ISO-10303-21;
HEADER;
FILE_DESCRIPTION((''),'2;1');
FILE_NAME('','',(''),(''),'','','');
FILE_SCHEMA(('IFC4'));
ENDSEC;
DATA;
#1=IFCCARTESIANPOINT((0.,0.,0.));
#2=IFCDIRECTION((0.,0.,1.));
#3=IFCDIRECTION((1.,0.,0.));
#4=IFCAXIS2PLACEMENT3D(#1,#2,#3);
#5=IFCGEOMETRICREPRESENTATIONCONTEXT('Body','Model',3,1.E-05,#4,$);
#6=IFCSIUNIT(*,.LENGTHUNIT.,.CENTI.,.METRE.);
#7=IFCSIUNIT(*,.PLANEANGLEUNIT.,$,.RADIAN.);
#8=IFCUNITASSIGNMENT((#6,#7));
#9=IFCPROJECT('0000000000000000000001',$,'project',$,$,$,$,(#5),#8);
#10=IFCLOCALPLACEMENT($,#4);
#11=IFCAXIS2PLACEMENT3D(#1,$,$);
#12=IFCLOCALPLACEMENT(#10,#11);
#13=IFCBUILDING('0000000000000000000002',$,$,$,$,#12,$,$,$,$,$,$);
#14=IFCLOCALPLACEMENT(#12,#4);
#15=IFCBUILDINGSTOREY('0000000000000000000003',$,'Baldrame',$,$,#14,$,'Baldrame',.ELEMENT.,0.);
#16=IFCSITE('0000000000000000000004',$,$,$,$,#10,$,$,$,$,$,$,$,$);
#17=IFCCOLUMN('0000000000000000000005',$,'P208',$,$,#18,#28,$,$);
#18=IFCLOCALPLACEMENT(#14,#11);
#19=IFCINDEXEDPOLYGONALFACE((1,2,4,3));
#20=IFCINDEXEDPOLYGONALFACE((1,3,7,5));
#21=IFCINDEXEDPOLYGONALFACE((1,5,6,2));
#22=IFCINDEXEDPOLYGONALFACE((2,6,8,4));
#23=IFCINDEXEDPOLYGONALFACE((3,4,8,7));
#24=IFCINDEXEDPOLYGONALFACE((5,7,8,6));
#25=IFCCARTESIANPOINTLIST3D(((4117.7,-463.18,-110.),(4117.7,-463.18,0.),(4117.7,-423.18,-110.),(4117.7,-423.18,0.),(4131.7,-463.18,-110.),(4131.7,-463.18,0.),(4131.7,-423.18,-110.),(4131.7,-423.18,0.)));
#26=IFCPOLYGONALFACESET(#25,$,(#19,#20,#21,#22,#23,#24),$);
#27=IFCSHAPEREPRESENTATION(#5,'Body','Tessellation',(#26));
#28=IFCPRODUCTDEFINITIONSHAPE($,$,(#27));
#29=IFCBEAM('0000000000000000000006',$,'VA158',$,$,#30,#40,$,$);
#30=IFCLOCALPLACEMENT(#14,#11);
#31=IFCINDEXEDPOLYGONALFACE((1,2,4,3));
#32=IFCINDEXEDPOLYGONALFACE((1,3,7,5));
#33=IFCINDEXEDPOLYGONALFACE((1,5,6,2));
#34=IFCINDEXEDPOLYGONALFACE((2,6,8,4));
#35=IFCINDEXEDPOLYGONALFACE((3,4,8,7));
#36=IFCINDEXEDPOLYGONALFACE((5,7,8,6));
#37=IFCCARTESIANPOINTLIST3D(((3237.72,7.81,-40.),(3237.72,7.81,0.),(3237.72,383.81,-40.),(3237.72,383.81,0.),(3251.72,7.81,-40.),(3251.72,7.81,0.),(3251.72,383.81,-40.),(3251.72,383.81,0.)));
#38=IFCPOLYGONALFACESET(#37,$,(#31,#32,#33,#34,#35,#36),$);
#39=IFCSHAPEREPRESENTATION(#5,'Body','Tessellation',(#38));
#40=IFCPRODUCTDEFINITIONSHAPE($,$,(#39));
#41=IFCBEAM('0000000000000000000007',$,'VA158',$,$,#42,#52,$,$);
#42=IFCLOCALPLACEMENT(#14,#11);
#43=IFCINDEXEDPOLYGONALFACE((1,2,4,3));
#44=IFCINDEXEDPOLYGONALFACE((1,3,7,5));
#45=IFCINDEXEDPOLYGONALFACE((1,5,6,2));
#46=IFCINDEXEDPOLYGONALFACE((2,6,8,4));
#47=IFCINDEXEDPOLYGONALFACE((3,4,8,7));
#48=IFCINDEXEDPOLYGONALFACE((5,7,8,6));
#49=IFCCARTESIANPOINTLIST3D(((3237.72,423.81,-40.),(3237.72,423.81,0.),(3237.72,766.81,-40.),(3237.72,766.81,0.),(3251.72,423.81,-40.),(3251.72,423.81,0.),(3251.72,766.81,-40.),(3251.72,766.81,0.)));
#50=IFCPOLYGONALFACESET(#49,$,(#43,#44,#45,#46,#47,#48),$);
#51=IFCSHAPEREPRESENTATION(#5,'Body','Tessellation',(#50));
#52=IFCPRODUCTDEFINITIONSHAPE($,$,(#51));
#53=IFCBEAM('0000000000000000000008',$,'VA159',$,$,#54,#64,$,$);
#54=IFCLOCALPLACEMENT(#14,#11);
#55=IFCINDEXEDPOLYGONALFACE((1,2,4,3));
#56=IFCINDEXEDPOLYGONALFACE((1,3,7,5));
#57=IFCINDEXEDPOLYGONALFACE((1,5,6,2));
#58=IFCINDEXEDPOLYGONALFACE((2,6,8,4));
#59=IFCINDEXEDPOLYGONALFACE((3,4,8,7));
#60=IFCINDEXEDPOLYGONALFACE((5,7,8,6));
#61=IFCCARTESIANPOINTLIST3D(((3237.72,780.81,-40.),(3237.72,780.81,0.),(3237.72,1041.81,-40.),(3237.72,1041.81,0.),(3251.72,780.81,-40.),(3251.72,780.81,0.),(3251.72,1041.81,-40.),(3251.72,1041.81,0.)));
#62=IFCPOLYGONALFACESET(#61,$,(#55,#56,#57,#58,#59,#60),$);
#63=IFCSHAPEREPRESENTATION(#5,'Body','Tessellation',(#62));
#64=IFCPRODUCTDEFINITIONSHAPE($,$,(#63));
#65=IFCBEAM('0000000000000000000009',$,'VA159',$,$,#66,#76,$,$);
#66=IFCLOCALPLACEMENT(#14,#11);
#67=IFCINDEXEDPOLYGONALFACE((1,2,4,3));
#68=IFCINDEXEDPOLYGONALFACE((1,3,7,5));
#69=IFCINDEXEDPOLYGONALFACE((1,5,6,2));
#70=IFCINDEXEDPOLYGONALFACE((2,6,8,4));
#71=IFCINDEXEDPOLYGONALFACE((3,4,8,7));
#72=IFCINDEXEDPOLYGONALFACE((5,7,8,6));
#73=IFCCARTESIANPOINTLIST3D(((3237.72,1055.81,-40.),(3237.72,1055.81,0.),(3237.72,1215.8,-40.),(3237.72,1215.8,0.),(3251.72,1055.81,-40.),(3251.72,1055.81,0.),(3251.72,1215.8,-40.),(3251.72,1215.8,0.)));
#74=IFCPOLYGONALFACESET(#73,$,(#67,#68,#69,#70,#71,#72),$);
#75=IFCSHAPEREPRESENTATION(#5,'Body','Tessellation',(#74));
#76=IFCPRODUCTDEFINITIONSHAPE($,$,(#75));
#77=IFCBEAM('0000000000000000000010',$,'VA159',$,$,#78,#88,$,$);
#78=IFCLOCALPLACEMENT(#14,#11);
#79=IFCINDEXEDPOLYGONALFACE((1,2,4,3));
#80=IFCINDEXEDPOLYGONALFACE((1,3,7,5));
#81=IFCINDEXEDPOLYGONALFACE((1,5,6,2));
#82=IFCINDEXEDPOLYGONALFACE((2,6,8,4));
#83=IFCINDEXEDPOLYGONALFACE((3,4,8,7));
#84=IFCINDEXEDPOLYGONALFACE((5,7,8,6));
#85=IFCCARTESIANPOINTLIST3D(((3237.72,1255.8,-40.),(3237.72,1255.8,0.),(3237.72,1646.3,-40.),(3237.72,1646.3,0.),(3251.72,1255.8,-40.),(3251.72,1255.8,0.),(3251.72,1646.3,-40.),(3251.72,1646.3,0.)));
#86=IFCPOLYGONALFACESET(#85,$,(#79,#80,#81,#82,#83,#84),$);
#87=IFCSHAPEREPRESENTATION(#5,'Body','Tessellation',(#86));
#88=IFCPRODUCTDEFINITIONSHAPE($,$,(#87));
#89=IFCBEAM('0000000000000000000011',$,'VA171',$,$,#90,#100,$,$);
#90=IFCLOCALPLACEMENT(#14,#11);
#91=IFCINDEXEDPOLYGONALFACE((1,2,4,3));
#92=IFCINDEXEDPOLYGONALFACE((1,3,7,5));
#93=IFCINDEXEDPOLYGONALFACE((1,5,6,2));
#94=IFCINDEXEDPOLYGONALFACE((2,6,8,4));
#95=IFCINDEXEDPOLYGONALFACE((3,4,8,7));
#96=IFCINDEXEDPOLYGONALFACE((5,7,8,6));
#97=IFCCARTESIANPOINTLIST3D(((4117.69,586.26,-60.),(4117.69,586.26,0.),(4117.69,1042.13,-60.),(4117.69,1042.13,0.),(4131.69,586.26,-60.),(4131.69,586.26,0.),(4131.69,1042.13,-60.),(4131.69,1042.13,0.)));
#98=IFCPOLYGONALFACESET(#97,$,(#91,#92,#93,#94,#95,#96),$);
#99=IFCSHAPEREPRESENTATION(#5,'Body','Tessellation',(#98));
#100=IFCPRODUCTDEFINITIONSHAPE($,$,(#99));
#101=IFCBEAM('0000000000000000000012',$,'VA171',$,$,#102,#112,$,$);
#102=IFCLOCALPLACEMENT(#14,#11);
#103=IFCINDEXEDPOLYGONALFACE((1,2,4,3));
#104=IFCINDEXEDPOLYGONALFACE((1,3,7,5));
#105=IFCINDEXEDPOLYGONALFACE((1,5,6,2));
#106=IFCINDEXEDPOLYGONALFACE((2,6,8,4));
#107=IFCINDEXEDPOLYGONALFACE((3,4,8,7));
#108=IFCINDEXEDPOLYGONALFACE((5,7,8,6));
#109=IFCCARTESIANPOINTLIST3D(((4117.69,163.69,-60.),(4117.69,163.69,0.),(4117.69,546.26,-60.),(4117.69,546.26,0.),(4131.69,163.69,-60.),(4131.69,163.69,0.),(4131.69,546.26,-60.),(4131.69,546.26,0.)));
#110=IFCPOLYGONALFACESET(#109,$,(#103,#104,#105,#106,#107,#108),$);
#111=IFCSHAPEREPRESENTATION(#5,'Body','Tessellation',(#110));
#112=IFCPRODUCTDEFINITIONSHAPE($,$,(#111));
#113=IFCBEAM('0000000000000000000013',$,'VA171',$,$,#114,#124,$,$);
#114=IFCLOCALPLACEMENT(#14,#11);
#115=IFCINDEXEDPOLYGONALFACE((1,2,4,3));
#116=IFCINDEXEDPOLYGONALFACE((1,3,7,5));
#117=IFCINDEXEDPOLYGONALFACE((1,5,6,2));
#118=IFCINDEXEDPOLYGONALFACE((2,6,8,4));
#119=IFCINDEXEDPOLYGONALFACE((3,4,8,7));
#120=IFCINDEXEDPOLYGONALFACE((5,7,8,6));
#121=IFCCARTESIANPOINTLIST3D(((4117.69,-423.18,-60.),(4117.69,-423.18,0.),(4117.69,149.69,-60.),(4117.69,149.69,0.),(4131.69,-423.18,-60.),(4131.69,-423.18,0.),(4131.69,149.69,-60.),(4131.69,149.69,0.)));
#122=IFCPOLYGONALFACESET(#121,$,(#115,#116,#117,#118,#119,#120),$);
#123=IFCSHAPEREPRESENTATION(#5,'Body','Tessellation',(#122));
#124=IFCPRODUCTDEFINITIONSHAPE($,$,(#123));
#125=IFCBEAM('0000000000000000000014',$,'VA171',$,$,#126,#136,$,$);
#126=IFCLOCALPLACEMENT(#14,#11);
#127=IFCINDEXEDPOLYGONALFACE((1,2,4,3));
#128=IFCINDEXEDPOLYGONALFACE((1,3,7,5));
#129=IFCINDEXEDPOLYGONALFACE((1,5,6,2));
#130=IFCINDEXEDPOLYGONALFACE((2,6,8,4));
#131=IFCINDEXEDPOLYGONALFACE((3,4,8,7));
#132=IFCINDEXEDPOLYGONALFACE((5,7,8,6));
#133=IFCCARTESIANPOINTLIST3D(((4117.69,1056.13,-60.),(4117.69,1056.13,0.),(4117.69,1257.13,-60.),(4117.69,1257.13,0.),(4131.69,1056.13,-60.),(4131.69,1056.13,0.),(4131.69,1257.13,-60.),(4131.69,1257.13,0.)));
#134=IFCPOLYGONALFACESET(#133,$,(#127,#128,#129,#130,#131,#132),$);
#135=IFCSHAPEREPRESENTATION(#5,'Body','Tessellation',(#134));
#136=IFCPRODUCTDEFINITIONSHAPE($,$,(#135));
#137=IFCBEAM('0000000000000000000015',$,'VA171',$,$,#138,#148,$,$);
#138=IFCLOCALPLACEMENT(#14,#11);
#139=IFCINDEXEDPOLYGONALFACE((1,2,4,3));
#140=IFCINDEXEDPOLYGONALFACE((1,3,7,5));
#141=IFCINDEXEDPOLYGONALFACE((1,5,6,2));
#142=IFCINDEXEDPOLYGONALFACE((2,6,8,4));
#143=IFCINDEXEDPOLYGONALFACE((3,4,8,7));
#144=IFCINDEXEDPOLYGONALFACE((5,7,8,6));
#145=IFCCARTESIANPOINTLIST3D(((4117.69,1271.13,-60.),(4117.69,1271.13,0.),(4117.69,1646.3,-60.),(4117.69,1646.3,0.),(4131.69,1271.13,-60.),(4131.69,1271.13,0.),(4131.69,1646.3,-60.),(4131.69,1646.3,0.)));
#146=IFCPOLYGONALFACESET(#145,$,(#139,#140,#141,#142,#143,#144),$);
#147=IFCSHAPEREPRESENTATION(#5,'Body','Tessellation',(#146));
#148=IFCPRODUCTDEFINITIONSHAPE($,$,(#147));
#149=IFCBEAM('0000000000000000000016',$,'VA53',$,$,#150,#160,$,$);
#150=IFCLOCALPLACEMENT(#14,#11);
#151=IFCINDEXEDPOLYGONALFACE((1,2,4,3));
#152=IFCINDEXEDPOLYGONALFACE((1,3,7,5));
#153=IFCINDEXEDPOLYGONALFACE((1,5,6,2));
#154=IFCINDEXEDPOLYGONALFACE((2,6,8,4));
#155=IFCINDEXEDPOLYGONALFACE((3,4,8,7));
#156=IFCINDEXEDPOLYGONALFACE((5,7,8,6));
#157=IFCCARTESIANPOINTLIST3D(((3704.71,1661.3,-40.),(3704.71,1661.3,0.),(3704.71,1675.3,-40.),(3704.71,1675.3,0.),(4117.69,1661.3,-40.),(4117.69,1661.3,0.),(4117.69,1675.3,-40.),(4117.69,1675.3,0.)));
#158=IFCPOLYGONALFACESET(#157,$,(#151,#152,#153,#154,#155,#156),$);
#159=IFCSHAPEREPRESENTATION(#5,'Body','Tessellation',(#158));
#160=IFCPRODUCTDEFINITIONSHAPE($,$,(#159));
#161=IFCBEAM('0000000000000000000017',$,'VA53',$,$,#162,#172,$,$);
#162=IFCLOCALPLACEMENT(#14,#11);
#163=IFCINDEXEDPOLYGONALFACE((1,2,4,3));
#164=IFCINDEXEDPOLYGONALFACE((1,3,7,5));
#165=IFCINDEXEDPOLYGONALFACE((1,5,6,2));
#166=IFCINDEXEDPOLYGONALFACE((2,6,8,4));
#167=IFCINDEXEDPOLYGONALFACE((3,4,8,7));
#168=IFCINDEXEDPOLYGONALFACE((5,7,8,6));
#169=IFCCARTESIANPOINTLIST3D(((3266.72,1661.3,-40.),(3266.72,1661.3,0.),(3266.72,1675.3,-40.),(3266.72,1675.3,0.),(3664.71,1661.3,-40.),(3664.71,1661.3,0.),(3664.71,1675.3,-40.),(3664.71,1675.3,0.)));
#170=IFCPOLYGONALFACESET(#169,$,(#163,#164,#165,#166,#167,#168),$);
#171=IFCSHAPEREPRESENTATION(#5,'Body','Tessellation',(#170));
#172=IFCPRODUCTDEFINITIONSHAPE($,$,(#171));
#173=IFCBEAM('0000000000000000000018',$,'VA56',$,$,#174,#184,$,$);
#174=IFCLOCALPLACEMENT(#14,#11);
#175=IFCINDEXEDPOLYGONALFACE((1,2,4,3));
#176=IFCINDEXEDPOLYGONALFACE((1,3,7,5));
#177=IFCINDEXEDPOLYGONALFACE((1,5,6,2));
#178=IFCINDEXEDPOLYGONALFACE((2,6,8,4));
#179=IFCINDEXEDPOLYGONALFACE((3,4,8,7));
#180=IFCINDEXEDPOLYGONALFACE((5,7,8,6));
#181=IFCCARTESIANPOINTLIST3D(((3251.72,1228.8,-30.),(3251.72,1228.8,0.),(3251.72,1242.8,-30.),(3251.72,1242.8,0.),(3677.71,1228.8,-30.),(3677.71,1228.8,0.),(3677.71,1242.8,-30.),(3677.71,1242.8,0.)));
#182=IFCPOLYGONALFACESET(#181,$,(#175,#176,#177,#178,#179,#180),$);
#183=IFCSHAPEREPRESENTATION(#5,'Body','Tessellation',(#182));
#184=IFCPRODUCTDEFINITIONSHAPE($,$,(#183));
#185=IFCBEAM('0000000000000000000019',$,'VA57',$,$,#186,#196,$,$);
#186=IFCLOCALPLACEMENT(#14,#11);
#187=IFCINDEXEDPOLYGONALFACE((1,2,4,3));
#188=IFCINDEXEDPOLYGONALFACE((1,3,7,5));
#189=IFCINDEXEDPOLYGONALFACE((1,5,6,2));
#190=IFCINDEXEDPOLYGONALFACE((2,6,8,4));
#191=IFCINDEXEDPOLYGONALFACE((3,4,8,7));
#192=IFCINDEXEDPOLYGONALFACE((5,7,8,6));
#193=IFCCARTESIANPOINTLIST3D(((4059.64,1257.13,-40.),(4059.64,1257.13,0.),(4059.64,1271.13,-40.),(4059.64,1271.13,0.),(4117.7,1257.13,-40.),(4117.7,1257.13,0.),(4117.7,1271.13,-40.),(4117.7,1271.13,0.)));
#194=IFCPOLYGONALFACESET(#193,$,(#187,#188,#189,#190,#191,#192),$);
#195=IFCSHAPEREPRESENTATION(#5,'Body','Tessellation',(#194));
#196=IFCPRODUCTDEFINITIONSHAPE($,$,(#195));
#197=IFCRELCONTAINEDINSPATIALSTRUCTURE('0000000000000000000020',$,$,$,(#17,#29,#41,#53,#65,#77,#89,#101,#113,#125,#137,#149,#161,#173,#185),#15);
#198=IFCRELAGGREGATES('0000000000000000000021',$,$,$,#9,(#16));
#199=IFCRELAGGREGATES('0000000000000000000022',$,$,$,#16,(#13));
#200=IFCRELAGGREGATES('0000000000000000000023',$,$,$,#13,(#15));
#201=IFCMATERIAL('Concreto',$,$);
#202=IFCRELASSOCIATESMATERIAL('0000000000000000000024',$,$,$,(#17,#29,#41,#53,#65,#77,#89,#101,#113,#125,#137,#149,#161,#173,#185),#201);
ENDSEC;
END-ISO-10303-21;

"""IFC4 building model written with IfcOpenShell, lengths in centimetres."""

from ifc_helpers import new_model, si_unit, frame, origin, origin_with_axes, origin_2d_with_axis, place, context, project, spatial, rectangle, extrude, material, element, save


model = new_model("IFC4")

# Units and contexts
model_context = context("Model", 3, precision=1e-05, world=origin_with_axes(), identifier="Body")
ifc_project = project(units=[si_unit("LENGTHUNIT", "METRE", prefix="CENTI"), si_unit("PLANEANGLEUNIT", "RADIAN")], contexts=[model_context])

# Site, building, storey
site_placement = place(None, origin_with_axes())
site = spatial("IfcSite", under=ifc_project, at=site_placement)
building_placement = place(site_placement, origin())
building = spatial("IfcBuilding", under=site, at=building_placement)
storey_placement = place(building_placement, origin_with_axes())
storey = spatial("IfcBuildingStorey", under=building, at=storey_placement, Name="Baldrame", LongName="Baldrame", CompositionType="ELEMENT", Elevation=0.0)

# Column
ifc_material = material(Name="Concreto")
column_1_placement = place(storey_placement, frame((4124.7, -443.18, 0.0), z_axis=(0.0, 0.0, 1.0), x_axis=(1.0, 0.0, 0.0)))
element("IfcColumn", 1, at=column_1_placement, inside=storey, material=ifc_material, Name="P208", context=model_context, shape_type="SolidModel", body=[
    extrude(rectangle(XDim=14.0, YDim=40.0, at=origin_2d_with_axis()), frame((0.0, 0.0, -110.0), z_axis=(0.0, 0.0, 1.0), x_axis=(1.0, 0.0, 0.0)), (0.0, 0.0, 1.0), 110.0),
])

# Beams
beam_1_placement = place(storey_placement, frame((3244.72, 195.81, 0.0), z_axis=(0.0, 0.0, 1.0), x_axis=(1.0, 0.0, 0.0)))
element("IfcBeam", 2, at=beam_1_placement, inside=storey, material=ifc_material, Name="VA158", context=model_context, shape_type="SolidModel", body=[
    extrude(rectangle(XDim=14.0, YDim=40.0, at=origin_2d_with_axis()), frame((0.0, -188.0, -20.0), z_axis=(0.0, 1.0, 0.0), x_axis=(1.0, 0.0, 0.0)), (0.0, 0.0, 1.0), 376.0),
])
beam_2_placement = place(storey_placement, frame((3244.72, 595.31, 0.0), z_axis=(0.0, 0.0, 1.0), x_axis=(1.0, 0.0, 0.0)))
element("IfcBeam", 3, at=beam_2_placement, inside=storey, material=ifc_material, Name="VA158", context=model_context, shape_type="SolidModel", body=[
    extrude(rectangle(XDim=14.0, YDim=40.0, at=origin_2d_with_axis()), frame((0.0, -171.5, -20.0), z_axis=(0.0, 1.0, 0.0), x_axis=(1.0, 0.0, 0.0)), (0.0, 0.0, 1.0), 343.0),
])
beam_3_placement = place(storey_placement, frame((3244.72, 911.31, 0.0), z_axis=(0.0, 0.0, 1.0), x_axis=(1.0, 0.0, 0.0)))
element("IfcBeam", 4, at=beam_3_placement, inside=storey, material=ifc_material, Name="VA159", context=model_context, shape_type="SolidModel", body=[
    extrude(rectangle(XDim=14.0, YDim=40.0, at=origin_2d_with_axis()), frame((0.0, -130.5, -20.0), z_axis=(0.0, 1.0, 0.0), x_axis=(1.0, 0.0, 0.0)), (0.0, 0.0, 1.0), 261.0),
])
beam_4_placement = place(storey_placement, frame((3244.72, 1135.81, 0.0), z_axis=(0.0, 0.0, 1.0), x_axis=(1.0, 0.0, 0.0)))
element("IfcBeam", 5, at=beam_4_placement, inside=storey, material=ifc_material, Name="VA159", context=model_context, shape_type="SolidModel", body=[
    extrude(rectangle(XDim=14.0, YDim=40.0, at=origin_2d_with_axis()), frame((0.0, -80.0, -20.0), z_axis=(0.0, 1.0, 0.0), x_axis=(1.0, 0.0, 0.0)), (0.0, 0.0, 1.0), 159.99),
])
beam_5_placement = place(storey_placement, frame((3244.72, 1451.05, 0.0), z_axis=(0.0, 0.0, 1.0), x_axis=(1.0, 0.0, 0.0)))
element("IfcBeam", 6, at=beam_5_placement, inside=storey, material=ifc_material, Name="VA159", context=model_context, shape_type="SolidModel", body=[
    extrude(rectangle(XDim=14.0, YDim=40.0, at=origin_2d_with_axis()), frame((0.0, -195.25, -20.0), z_axis=(0.0, 1.0, 0.0), x_axis=(1.0, 0.0, 0.0)), (0.0, 0.0, 1.0), 390.5),
])
beam_6_placement = place(storey_placement, frame((4124.69, 814.2, 0.0), z_axis=(0.0, 0.0, 1.0), x_axis=(1.0, 0.0, 0.0)))
element("IfcBeam", 7, at=beam_6_placement, inside=storey, material=ifc_material, Name="VA171", context=model_context, shape_type="SolidModel", body=[
    extrude(rectangle(XDim=14.0, YDim=60.0, at=origin_2d_with_axis()), frame((0.0, -227.94, -30.0), z_axis=(0.0, 1.0, 0.0), x_axis=(1.0, 0.0, 0.0)), (0.0, 0.0, 1.0), 455.87),
])
beam_7_placement = place(storey_placement, frame((4124.69, 354.98, 0.0), z_axis=(0.0, 0.0, 1.0), x_axis=(1.0, 0.0, 0.0)))
element("IfcBeam", 8, at=beam_7_placement, inside=storey, material=ifc_material, Name="VA171", context=model_context, shape_type="SolidModel", body=[
    extrude(rectangle(XDim=14.0, YDim=60.0, at=origin_2d_with_axis()), frame((0.0, -191.28, -30.0), z_axis=(0.0, 1.0, 0.0), x_axis=(1.0, 0.0, 0.0)), (0.0, 0.0, 1.0), 382.57),
])
beam_8_placement = place(storey_placement, frame((4124.69, -136.75, 0.0), z_axis=(0.0, 0.0, 1.0), x_axis=(1.0, 0.0, 0.0)))
element("IfcBeam", 9, at=beam_8_placement, inside=storey, material=ifc_material, Name="VA171", context=model_context, shape_type="SolidModel", body=[
    extrude(rectangle(XDim=14.0, YDim=60.0, at=origin_2d_with_axis()), frame((0.0, -286.44, -30.0), z_axis=(0.0, 1.0, 0.0), x_axis=(1.0, 0.0, 0.0)), (0.0, 0.0, 1.0), 572.87),
])
beam_9_placement = place(storey_placement, frame((4124.69, 1156.63, 0.0), z_axis=(0.0, 0.0, 1.0), x_axis=(1.0, 0.0, 0.0)))
element("IfcBeam", 10, at=beam_9_placement, inside=storey, material=ifc_material, Name="VA171", context=model_context, shape_type="SolidModel", body=[
    extrude(rectangle(XDim=14.0, YDim=60.0, at=origin_2d_with_axis()), frame((0.0, -100.5, -30.0), z_axis=(0.0, 1.0, 0.0), x_axis=(1.0, 0.0, 0.0)), (0.0, 0.0, 1.0), 201.0),
])
beam_10_placement = place(storey_placement, frame((4124.69, 1458.71, 0.0), z_axis=(0.0, 0.0, 1.0), x_axis=(1.0, 0.0, 0.0)))
element("IfcBeam", 11, at=beam_10_placement, inside=storey, material=ifc_material, Name="VA171", context=model_context, shape_type="SolidModel", body=[
    extrude(rectangle(XDim=14.0, YDim=60.0, at=origin_2d_with_axis()), frame((0.0, -187.59, -30.0), z_axis=(0.0, 1.0, 0.0), x_axis=(1.0, 0.0, 0.0)), (0.0, 0.0, 1.0), 375.17),
])
beam_11_placement = place(storey_placement, frame((3911.2, 1668.3, 0.0), z_axis=(0.0, 0.0, 1.0), x_axis=(1.0, 0.0, 0.0)))
element("IfcBeam", 12, at=beam_11_placement, inside=storey, material=ifc_material, Name="VA53", context=model_context, shape_type="SolidModel", body=[
    extrude(rectangle(XDim=14.0, YDim=40.0, at=origin_2d_with_axis()), frame((-206.49, 0.0, -20.0), z_axis=(1.0, 0.0, 0.0), x_axis=(0.0, 1.0, 0.0)), (0.0, 0.0, 1.0), 412.98),
])
beam_12_placement = place(storey_placement, frame((3465.72, 1668.3, 0.0), z_axis=(0.0, 0.0, 1.0), x_axis=(1.0, 0.0, 0.0)))
element("IfcBeam", 13, at=beam_12_placement, inside=storey, material=ifc_material, Name="VA53", context=model_context, shape_type="SolidModel", body=[
    extrude(rectangle(XDim=14.0, YDim=40.0, at=origin_2d_with_axis()), frame((-199.0, 0.0, -20.0), z_axis=(1.0, 0.0, 0.0), x_axis=(0.0, 1.0, 0.0)), (0.0, 0.0, 1.0), 397.99),
])
beam_13_placement = place(storey_placement, frame((3464.72, 1235.8, 0.0), z_axis=(0.0, 0.0, 1.0), x_axis=(1.0, 0.0, 0.0)))
element("IfcBeam", 14, at=beam_13_placement, inside=storey, material=ifc_material, Name="VA56", context=model_context, shape_type="SolidModel", body=[
    extrude(rectangle(XDim=14.0, YDim=30.0, at=origin_2d_with_axis()), frame((-213.0, 0.0, -15.0), z_axis=(1.0, 0.0, 0.0), x_axis=(0.0, 1.0, 0.0)), (0.0, 0.0, 1.0), 425.99),
])
beam_14_placement = place(storey_placement, frame((4088.67, 1264.13, 0.0), z_axis=(0.0, 0.0, 1.0), x_axis=(1.0, 0.0, 0.0)))
element("IfcBeam", 15, at=beam_14_placement, inside=storey, material=ifc_material, Name="VA57", context=model_context, shape_type="SolidModel", body=[
    extrude(rectangle(XDim=14.0, YDim=40.0, at=origin_2d_with_axis()), frame((-29.03, 0.0, -20.0), z_axis=(1.0, 0.0, 0.0), x_axis=(0.0, 1.0, 0.0)), (0.0, 0.0, 1.0), 58.06),
])

save(model, "model.ifc")
